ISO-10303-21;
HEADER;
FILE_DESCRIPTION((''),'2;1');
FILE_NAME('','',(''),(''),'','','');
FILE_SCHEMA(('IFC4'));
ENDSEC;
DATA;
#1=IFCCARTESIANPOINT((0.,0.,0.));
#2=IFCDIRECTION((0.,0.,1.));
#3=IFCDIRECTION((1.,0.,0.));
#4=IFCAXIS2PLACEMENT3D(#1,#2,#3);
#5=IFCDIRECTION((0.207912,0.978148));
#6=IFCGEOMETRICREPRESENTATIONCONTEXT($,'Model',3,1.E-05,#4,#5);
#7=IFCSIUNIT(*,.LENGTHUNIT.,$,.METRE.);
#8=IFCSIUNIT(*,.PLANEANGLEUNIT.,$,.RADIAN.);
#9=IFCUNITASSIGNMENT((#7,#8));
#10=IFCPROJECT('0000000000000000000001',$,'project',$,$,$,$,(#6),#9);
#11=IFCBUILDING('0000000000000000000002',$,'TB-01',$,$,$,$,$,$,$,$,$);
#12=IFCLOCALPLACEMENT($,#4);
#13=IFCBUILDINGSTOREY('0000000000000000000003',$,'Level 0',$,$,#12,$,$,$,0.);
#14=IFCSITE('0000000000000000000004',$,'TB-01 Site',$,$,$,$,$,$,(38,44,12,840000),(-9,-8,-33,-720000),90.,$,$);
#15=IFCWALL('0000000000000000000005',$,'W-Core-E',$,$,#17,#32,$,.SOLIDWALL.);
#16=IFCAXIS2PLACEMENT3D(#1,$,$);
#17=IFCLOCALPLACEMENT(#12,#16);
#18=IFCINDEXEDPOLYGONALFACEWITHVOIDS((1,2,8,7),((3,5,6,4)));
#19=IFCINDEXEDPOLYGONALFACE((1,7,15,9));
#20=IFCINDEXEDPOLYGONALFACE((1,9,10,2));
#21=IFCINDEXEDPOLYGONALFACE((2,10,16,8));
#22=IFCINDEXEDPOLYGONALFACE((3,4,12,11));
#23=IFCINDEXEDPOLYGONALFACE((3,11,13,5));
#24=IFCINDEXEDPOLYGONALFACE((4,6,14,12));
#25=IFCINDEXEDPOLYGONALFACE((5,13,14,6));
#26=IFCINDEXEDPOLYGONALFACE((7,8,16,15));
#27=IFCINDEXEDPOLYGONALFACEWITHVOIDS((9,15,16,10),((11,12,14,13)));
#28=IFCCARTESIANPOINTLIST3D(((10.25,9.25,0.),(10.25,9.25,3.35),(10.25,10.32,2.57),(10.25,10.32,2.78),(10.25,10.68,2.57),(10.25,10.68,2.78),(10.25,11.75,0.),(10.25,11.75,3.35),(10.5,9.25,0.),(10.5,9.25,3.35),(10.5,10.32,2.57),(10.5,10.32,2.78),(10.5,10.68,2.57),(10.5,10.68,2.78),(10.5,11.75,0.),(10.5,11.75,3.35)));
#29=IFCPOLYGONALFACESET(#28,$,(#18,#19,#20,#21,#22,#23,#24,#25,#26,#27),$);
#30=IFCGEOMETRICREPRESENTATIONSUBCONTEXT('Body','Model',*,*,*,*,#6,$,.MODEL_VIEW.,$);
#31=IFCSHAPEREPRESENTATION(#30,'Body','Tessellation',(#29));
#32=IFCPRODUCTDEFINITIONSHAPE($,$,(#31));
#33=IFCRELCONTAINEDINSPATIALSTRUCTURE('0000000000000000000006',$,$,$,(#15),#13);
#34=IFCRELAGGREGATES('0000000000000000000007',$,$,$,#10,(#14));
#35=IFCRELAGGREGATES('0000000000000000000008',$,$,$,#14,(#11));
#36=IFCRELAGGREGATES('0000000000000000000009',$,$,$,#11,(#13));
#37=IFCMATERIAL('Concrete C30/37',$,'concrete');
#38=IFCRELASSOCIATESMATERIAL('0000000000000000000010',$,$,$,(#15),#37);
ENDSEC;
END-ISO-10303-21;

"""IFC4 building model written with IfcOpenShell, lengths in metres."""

from ifc_helpers import new_model, si_unit, direction, frame, origin_with_axes, place, context, subcontext, project, spatial, rectangle, extrude, material, element, save


model = new_model("IFC4")

# Units and contexts
model_context = context("Model", 3, precision=1e-05, world=origin_with_axes(), true_north=direction((0.207912, 0.978148)))
body_context = subcontext(model_context, "Body", "Model", "MODEL_VIEW")
ifc_project = project(units=[si_unit("LENGTHUNIT", "METRE"), si_unit("PLANEANGLEUNIT", "RADIAN")], contexts=[model_context])

# Site, building, storey
site = spatial("IfcSite", under=ifc_project, Name="TB-01 Site", RefLatitude=(38, 44, 12, 840000), RefLongitude=(-9, -8, -33, -720000), RefElevation=90.0)
building = spatial("IfcBuilding", under=site, Name="TB-01")
storey_placement = place(None, origin_with_axes())
storey = spatial("IfcBuildingStorey", under=building, at=storey_placement, Name="Level 0", Elevation=0.0)

# Shared definitions
ifc_material = material(Name="Concrete C30/37", Category="concrete")

# Wall, opening
wall_1_placement = place(storey_placement, frame((10.375, 10.5, 0.0), z_axis=(0.0, 0.0, 1.0), x_axis=(1.0, 0.0, 0.0)))
wall_1 = element("IfcWall", 1, at=wall_1_placement, inside=storey, material=ifc_material, Name="W-Core-E", PredefinedType="SOLIDWALL", context=body_context, shape_type="SweptSolid", body=[
    extrude(rectangle(XDim=0.25, YDim=2.5), origin_with_axes(), (0.0, 0.0, 1.0), 3.35),
])
opening_1_placement = place(wall_1_placement, frame((0.0, 0.0, 2.57), z_axis=(0.0, 0.0, 1.0), x_axis=(1.0, 0.0, 0.0)))
element("IfcOpeningElement", 2, at=opening_1_placement, cuts=wall_1, context=body_context, shape_type="SweptSolid", body=[
    extrude(rectangle(XDim=0.35, YDim=0.36), origin_with_axes(), (0.0, 0.0, 1.0), 0.21),
])

save(model, "model.ifc")
